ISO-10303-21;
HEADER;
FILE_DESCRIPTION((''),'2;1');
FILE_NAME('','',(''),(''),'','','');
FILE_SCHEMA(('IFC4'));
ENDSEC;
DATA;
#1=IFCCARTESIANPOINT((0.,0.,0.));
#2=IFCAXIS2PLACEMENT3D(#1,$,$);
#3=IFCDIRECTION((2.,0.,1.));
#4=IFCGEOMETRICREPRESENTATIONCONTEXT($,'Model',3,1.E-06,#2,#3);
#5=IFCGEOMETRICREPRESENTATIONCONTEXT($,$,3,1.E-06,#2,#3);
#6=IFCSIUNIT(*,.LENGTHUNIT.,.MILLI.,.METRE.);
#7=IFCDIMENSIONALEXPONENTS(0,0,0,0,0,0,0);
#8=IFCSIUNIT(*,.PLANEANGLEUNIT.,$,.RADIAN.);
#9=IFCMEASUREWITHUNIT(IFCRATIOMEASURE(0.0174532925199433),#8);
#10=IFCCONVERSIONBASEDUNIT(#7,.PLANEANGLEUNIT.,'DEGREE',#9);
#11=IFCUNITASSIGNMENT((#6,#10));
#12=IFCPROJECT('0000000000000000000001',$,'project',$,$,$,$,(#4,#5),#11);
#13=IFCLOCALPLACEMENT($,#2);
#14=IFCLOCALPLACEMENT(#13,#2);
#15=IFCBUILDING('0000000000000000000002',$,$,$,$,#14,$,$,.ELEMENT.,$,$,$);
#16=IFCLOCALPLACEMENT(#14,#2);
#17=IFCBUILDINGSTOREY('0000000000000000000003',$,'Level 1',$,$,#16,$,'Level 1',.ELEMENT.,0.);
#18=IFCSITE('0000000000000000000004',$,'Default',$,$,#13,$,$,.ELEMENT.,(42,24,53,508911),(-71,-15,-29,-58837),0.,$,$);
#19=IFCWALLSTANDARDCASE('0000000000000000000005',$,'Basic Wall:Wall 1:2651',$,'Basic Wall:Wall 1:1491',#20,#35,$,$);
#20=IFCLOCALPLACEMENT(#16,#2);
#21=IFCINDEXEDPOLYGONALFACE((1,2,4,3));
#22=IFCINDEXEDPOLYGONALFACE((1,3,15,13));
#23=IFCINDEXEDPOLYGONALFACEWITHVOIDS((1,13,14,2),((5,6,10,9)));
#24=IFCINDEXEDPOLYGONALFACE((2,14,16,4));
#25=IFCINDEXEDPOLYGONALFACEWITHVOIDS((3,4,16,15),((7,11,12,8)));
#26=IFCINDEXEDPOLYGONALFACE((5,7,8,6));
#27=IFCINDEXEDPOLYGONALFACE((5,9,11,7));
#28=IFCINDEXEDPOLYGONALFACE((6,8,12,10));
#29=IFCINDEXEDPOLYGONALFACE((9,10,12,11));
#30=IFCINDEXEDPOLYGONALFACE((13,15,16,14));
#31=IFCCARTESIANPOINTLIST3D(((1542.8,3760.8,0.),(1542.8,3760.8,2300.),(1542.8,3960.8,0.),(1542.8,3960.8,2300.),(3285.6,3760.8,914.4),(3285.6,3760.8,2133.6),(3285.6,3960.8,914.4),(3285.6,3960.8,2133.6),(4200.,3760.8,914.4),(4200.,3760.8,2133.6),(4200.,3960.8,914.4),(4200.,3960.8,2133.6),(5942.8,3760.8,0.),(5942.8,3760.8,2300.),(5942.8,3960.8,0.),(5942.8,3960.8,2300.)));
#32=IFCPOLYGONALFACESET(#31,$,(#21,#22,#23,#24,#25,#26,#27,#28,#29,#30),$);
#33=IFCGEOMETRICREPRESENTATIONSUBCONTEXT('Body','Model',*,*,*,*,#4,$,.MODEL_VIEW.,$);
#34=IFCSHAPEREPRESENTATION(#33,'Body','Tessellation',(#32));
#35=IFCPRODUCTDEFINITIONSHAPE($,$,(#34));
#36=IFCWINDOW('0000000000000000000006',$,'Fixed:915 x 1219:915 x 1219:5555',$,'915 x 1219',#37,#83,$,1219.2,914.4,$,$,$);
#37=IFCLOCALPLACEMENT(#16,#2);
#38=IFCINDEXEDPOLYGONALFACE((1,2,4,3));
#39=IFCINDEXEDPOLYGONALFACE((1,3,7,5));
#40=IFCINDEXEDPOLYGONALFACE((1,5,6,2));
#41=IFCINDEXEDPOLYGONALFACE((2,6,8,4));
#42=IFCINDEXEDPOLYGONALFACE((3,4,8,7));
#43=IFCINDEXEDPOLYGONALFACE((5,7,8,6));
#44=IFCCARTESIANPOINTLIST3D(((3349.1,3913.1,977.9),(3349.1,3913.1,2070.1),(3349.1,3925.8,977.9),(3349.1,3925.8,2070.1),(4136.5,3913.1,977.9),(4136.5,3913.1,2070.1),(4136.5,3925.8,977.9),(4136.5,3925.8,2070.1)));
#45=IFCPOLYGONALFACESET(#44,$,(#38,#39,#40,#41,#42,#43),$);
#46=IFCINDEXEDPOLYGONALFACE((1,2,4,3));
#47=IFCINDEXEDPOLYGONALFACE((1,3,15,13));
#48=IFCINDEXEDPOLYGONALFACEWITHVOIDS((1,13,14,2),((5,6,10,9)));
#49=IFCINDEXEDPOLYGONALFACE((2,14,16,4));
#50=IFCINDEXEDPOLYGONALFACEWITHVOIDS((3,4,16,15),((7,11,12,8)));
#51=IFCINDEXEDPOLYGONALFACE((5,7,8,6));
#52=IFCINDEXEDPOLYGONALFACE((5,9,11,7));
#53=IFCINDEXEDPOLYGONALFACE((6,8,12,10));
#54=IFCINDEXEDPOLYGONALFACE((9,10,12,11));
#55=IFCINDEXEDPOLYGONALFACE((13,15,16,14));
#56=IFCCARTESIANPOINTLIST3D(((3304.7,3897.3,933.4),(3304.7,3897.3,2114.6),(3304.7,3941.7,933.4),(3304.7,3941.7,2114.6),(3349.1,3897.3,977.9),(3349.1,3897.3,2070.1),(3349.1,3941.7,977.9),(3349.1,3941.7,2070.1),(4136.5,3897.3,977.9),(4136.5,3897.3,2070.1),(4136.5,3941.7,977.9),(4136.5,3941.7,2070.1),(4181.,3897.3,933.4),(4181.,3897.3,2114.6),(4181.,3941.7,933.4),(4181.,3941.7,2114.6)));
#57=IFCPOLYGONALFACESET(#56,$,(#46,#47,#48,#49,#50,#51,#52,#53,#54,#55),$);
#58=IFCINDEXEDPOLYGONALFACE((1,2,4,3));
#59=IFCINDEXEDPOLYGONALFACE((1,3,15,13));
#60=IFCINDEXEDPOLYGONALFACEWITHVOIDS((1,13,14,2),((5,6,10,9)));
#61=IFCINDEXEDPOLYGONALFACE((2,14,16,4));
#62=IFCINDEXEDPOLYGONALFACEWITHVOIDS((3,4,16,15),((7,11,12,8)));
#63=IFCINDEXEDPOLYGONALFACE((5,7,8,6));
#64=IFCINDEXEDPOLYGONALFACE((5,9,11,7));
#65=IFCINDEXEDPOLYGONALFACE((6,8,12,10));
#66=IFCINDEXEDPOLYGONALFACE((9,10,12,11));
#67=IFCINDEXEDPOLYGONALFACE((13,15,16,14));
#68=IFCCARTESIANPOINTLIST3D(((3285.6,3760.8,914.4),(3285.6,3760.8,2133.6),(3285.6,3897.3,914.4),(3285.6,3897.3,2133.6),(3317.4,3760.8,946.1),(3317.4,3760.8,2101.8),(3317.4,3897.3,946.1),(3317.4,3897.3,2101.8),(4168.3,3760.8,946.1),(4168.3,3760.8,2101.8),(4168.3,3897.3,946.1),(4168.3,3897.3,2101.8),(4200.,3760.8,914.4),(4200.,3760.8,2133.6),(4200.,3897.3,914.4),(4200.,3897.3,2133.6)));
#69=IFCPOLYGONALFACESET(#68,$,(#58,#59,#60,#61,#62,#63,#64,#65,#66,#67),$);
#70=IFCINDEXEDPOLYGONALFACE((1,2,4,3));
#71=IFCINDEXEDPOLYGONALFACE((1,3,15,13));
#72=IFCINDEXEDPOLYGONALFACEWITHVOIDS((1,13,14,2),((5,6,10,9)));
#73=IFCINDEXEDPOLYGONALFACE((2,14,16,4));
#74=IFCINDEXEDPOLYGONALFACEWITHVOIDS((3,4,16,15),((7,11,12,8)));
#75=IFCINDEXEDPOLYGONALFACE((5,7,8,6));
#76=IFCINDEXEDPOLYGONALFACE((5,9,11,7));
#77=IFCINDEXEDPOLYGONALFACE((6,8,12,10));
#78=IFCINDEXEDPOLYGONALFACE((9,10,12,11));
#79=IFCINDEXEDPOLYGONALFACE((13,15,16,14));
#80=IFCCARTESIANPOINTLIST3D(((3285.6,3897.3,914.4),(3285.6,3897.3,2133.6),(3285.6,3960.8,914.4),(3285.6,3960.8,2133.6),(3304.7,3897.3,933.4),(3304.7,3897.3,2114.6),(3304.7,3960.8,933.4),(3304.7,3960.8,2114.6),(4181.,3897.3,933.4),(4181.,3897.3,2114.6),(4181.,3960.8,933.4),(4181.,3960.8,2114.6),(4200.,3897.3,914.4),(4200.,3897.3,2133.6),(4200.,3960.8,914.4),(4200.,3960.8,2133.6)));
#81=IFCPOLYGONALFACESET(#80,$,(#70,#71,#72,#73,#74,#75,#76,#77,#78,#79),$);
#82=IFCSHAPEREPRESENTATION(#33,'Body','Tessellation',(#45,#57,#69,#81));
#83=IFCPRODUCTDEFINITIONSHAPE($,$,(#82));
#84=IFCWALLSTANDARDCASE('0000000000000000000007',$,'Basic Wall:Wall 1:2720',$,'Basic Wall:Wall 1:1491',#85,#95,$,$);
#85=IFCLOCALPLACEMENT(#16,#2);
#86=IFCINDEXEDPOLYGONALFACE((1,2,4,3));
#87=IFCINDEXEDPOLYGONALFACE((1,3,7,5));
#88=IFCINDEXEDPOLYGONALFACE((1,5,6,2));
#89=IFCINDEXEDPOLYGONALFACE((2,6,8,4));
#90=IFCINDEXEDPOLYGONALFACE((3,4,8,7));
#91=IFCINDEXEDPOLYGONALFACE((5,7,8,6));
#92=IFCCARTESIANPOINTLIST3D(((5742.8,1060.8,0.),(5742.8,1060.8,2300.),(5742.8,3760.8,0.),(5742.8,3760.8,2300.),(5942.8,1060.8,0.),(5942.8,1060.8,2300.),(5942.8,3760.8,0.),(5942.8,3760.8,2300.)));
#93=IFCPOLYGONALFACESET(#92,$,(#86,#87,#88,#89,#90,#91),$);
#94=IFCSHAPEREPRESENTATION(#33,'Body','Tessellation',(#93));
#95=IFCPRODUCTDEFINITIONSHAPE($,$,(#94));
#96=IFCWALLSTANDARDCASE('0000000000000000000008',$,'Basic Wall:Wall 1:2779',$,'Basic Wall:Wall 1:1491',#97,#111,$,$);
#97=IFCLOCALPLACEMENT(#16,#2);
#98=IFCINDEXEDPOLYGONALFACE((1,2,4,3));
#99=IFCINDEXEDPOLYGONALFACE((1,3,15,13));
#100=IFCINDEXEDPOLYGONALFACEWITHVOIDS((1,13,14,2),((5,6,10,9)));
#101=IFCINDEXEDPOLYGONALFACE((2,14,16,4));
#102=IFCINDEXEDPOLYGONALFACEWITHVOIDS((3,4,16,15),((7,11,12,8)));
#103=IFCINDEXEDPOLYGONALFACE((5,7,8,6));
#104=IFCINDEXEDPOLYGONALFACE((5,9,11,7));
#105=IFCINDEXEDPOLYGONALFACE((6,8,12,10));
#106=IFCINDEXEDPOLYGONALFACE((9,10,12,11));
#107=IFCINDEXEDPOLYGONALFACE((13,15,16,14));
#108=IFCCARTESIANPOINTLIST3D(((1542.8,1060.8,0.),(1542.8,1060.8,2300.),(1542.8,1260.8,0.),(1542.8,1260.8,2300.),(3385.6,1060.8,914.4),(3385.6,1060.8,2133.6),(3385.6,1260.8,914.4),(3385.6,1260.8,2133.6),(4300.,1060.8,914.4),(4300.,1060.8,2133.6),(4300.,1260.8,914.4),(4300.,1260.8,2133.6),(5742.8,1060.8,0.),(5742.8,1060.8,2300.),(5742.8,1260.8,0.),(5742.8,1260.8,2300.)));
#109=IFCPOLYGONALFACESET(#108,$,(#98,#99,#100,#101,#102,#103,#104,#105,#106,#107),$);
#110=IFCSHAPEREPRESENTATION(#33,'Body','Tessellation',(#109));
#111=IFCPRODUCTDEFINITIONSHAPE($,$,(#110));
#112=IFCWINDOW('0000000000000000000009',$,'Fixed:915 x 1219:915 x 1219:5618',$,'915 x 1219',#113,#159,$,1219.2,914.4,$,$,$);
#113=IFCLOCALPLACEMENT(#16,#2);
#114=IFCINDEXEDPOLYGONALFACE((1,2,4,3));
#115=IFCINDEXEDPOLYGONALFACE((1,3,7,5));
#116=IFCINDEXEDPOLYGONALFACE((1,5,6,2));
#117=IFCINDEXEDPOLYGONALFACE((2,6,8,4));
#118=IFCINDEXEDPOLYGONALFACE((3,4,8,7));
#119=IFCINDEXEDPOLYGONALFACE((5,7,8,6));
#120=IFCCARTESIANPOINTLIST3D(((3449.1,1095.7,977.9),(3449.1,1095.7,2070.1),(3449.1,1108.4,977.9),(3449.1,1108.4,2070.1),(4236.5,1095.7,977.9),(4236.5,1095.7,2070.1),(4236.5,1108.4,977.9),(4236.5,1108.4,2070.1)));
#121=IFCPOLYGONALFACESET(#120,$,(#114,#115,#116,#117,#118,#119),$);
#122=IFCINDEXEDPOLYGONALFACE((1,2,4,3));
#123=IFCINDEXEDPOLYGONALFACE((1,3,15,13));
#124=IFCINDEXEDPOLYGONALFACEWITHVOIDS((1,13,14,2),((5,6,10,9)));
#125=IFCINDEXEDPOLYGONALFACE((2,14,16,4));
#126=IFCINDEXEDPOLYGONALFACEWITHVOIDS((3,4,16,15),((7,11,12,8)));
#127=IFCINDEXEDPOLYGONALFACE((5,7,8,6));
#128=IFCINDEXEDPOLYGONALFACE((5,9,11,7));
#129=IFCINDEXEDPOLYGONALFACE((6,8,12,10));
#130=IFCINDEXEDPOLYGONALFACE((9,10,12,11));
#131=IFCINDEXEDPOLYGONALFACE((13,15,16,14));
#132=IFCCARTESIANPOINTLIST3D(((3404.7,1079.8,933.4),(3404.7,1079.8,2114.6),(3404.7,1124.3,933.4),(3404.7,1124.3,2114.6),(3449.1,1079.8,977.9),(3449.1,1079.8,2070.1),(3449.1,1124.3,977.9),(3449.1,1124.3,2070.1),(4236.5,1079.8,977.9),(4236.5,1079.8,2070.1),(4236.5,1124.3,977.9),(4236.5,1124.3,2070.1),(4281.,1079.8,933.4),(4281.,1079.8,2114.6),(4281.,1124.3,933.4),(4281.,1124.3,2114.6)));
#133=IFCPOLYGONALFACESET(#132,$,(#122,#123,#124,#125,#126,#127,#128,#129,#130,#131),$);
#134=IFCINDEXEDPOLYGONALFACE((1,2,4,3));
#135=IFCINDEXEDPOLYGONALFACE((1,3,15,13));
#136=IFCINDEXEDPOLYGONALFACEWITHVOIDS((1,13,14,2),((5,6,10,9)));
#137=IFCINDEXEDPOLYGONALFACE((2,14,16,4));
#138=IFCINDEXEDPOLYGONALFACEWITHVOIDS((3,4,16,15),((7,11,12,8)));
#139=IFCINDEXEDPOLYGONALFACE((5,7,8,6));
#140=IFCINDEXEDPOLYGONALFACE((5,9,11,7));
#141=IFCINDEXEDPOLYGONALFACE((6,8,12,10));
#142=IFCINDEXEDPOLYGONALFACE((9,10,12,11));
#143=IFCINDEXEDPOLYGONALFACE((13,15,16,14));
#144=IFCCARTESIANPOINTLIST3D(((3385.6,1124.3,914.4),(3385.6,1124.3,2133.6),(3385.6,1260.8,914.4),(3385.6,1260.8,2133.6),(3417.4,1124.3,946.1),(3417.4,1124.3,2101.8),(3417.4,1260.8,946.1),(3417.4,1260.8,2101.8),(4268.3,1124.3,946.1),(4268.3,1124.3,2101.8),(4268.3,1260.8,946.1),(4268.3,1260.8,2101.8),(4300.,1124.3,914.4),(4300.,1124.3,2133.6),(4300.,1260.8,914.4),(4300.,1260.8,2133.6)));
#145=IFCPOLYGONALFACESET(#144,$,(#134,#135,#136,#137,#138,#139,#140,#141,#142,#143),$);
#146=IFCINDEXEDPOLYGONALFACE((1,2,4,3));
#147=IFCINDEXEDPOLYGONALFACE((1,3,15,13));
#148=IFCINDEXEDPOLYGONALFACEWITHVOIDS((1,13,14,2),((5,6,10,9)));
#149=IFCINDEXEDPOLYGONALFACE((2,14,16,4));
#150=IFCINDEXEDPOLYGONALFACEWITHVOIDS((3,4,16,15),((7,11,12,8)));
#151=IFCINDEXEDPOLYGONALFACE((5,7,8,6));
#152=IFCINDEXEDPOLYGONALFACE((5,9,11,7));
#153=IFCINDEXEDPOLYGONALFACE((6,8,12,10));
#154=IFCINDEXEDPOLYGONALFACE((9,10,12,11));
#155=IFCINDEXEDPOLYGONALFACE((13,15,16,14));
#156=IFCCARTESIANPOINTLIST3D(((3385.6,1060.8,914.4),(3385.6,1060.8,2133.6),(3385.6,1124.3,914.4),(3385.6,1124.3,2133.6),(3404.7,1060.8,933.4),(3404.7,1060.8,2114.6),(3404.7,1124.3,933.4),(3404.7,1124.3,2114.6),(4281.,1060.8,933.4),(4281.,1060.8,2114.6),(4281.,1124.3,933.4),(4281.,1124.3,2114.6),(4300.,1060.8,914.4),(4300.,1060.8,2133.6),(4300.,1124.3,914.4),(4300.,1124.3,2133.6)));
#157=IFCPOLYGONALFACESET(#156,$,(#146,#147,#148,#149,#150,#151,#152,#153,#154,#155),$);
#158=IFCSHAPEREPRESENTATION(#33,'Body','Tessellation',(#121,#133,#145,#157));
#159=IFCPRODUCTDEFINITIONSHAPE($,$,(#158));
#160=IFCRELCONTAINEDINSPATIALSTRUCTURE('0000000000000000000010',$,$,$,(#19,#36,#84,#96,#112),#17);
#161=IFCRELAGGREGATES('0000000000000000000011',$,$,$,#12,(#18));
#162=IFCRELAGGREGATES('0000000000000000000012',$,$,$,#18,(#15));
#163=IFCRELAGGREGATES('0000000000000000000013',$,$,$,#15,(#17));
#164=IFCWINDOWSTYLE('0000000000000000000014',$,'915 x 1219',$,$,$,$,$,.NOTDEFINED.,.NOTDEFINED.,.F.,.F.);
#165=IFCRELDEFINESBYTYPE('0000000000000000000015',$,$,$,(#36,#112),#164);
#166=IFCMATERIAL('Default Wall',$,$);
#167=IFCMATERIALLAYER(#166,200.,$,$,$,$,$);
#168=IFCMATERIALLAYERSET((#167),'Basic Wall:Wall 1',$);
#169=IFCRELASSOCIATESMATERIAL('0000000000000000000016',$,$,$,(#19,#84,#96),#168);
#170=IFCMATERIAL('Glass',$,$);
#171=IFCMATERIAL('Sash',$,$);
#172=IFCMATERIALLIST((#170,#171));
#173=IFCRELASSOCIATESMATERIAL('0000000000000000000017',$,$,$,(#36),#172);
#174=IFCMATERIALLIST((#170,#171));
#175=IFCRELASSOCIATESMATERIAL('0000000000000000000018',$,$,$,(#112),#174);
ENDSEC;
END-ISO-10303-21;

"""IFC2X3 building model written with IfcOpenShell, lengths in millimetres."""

from ifc_helpers import new_model, entity, si_unit, converted_unit, direction, frame, frame_2d, origin, place, context, subcontext, project, spatial, polyline, rectangle, outline, extrude, source, transform, mapped, material, material_list, layer, layer_set, layer_usage, type_object, type_shapes, element, fill, save


model = new_model("IFC2X3")

# Units and contexts
model_context = context("Model", 3, precision=1e-06, world=origin(), true_north=direction((2.0, 0.0, 1.0)))
context_of_model = context(None, 3, precision=1e-06, world=origin(), true_north=direction((2.0, 0.0, 1.0)))
body_context = subcontext(model_context, "Body", "Model", "MODEL_VIEW")
ifc_project = project(units=[si_unit("LENGTHUNIT", "METRE", prefix="MILLI"), converted_unit("PLANEANGLEUNIT", "DEGREE", entity("IfcRatioMeasure", 0.0174532925199433), si_unit("PLANEANGLEUNIT", "RADIAN"), dimensions=[0, 0, 0, 0, 0, 0, 0])], contexts=[model_context, context_of_model])

# Site, building, storey
site_placement = place(None, origin())
site = spatial("IfcSite", under=ifc_project, at=site_placement, Name="Default", CompositionType="ELEMENT", RefLatitude=(42, 24, 53, 508911), RefLongitude=(-71, -15, -29, -58837), RefElevation=0.0)
building_placement = place(site_placement, origin())
building = spatial("IfcBuilding", under=site, at=building_placement, CompositionType="ELEMENT")
storey_placement = place(building_placement, origin())
storey = spatial("IfcBuildingStorey", under=building, at=storey_placement, Name="Level 1", LongName="Level 1", CompositionType="ELEMENT", Elevation=0.0)

# Wall, opening, window
ifc_material_1 = material(Name="Default Wall")
ifc_layer = layer(ifc_material_1, 200.0)
ifc_layer_set = layer_set([ifc_layer], Name="Basic Wall:Wall 1")
ifc_layer_usage_1 = layer_usage(ifc_layer_set, "AXIS2", "NEGATIVE", 100.0)
wall_1_placement = place(storey_placement, frame((1542.8, 3860.8, 0.0)))
wall_1 = element("IfcWallStandardCase", 1, at=wall_1_placement, inside=storey, material=ifc_layer_usage_1, Name="Basic Wall:Wall 1:2651", ObjectType="Basic Wall:Wall 1:1491", context=body_context, shape_type="SweptSolid", body=[
    extrude(rectangle(XDim=4400.0, YDim=200.0, at=frame_2d((2200.0, 0.0), x_axis=(-1.0, 0.0))), origin(), (0.0, 0.0, 1.0), 2300.0),
])
opening_1_placement = place(wall_1_placement, frame((1742.8, -100.0, 914.4)))
opening_1 = element("IfcOpeningElement", 2, at=opening_1_placement, cuts=wall_1, ObjectType="Opening", context=body_context, shape_type="SweptSolid", body=[
    extrude(rectangle(XDim=1219.2, YDim=914.4, at=frame_2d((609.6, 457.2), x_axis=(-1.0, 0.0))), frame((0.0, 0.0, 0.0), z_axis=(0.0, 1.0, 0.0), x_axis=(0.0, 0.0, 1.0)), (0.0, 0.0, 1.0), 200.0),
])
ifc_material_2 = material(Name="Glass")
ifc_material_3 = material(Name="Sash")
ifc_material_list_1 = material_list([ifc_material_2, ifc_material_3])
window_style = type_object("IfcWindowStyle", Name="915 x 1219", ConstructionType="NOTDEFINED", OperationType="NOTDEFINED", ParameterTakesPrecedence=False, Sizeable=False)
shared_shape_1 = source(origin(), body_context, "Body", "SweptSolid", [
    extrude(rectangle(XDim=12.7, YDim=787.4, at=frame_2d((0.0, 0.0), x_axis=(1.0, 0.0))), frame((457.2, 158.7, 63.5), z_axis=(0.0, 0.0, 1.0), x_axis=(0.0, 1.0, 0.0)), (0.0, 0.0, 1.0), 1092.2),
    extrude(outline(polyline([(-438.1, -590.6), (438.1, -590.6), (438.1, 590.6), (-438.1, 590.6), (-438.1, -590.6)]), holes=[polyline([(-393.7, -546.1), (-393.7, 546.1), (393.7, 546.1), (393.7, -546.1), (-393.7, -546.1)])]), frame((457.2, 136.5, 609.6), z_axis=(0.0, 1.0, 0.0), x_axis=(1.0, 0.0, 0.0)), (0.0, 0.0, 1.0), 44.5),
    extrude(outline(polyline([(-457.2, -609.6), (457.2, -609.6), (457.2, 609.6), (-457.2, 609.6), (-457.2, -609.6)]), holes=[polyline([(-425.5, -577.8), (-425.5, 577.9), (425.4, 577.9), (425.4, -577.8), (-425.5, -577.8)])]), frame((457.2, 0.0, 609.6), z_axis=(0.0, 1.0, 0.0), x_axis=(1.0, 0.0, 0.0)), (0.0, 0.0, 1.0), 136.5),
    extrude(outline(polyline([(-609.6, -457.2), (609.6, -457.2), (609.6, 457.2), (-609.6, 457.2), (-609.6, -457.2)]), holes=[polyline([(-590.5, -438.1), (-590.5, 438.1), (590.6, 438.1), (590.6, -438.1), (-590.5, -438.1)])]), frame((457.2, 136.5, 609.6), z_axis=(0.0, 1.0, 0.0), x_axis=(0.0, 0.0, -1.0)), (0.0, 0.0, 1.0), 63.5),
])
type_shapes(window_style, [shared_shape_1])
window_1_placement = place(opening_1_placement, origin())
window_1 = element("IfcWindow", 3, at=window_1_placement, inside=storey, type_object=window_style, material=ifc_material_list_1, Name="Fixed:915 x 1219:915 x 1219:5555", ObjectType="915 x 1219", OverallHeight=1219.2, OverallWidth=914.4, context=body_context, shape_type="MappedRepresentation", body=[
    mapped(shared_shape_1, transform((0.0, 0.0, 0.0), scale=1.0)),
])
fill(opening_1, window_1)

# Wall
ifc_layer_usage_2 = layer_usage(ifc_layer_set, "AXIS2", "NEGATIVE", 100.0)
wall_2_placement = place(storey_placement, frame((5842.8, 3760.8, 0.0), z_axis=(0.0, 0.0, 1.0), x_axis=(0.0, -1.0, 0.0)))
element("IfcWallStandardCase", 4, at=wall_2_placement, inside=storey, material=ifc_layer_usage_2, Name="Basic Wall:Wall 1:2720", ObjectType="Basic Wall:Wall 1:1491", context=body_context, shape_type="SweptSolid", body=[
    extrude(rectangle(XDim=2700.0, YDim=200.0, at=frame_2d((1350.0, 0.0), x_axis=(-1.0, 0.0))), origin(), (0.0, 0.0, 1.0), 2300.0),
])

# Wall, opening, window
ifc_layer_usage_3 = layer_usage(ifc_layer_set, "AXIS2", "NEGATIVE", 100.0)
wall_3_placement = place(storey_placement, frame((5742.8, 1160.8, 0.0), z_axis=(0.0, 0.0, 1.0), x_axis=(-1.0, 0.0, 0.0)))
wall_3 = element("IfcWallStandardCase", 5, at=wall_3_placement, inside=storey, material=ifc_layer_usage_3, Name="Basic Wall:Wall 1:2779", ObjectType="Basic Wall:Wall 1:1491", context=body_context, shape_type="SweptSolid", body=[
    extrude(rectangle(XDim=4200.0, YDim=200.0, at=frame_2d((2100.0, 0.0), x_axis=(-1.0, 0.0))), origin(), (0.0, 0.0, 1.0), 2300.0),
])
opening_2_placement = place(wall_3_placement, frame((1442.8, -100.0, 914.4)))
opening_2 = element("IfcOpeningElement", 6, at=opening_2_placement, cuts=wall_3, ObjectType="Opening", context=body_context, shape_type="SweptSolid", body=[
    extrude(rectangle(XDim=1219.2, YDim=914.4, at=frame_2d((609.6, 457.2), x_axis=(-1.0, 0.0))), frame((0.0, 0.0, 0.0), z_axis=(0.0, 1.0, 0.0), x_axis=(0.0, 0.0, 1.0)), (0.0, 0.0, 1.0), 200.0),
])
ifc_material_list_2 = material_list([ifc_material_2, ifc_material_3])
window_2_placement = place(opening_2_placement, origin())
window_2 = element("IfcWindow", 7, at=window_2_placement, inside=storey, type_object=window_style, material=ifc_material_list_2, Name="Fixed:915 x 1219:915 x 1219:5618", ObjectType="915 x 1219", OverallHeight=1219.2, OverallWidth=914.4, context=body_context, shape_type="MappedRepresentation", body=[
    mapped(shared_shape_1, transform((0.0, 0.0, 0.0), scale=1.0)),
])
fill(opening_2, window_2)

save(model, "model.ifc")
